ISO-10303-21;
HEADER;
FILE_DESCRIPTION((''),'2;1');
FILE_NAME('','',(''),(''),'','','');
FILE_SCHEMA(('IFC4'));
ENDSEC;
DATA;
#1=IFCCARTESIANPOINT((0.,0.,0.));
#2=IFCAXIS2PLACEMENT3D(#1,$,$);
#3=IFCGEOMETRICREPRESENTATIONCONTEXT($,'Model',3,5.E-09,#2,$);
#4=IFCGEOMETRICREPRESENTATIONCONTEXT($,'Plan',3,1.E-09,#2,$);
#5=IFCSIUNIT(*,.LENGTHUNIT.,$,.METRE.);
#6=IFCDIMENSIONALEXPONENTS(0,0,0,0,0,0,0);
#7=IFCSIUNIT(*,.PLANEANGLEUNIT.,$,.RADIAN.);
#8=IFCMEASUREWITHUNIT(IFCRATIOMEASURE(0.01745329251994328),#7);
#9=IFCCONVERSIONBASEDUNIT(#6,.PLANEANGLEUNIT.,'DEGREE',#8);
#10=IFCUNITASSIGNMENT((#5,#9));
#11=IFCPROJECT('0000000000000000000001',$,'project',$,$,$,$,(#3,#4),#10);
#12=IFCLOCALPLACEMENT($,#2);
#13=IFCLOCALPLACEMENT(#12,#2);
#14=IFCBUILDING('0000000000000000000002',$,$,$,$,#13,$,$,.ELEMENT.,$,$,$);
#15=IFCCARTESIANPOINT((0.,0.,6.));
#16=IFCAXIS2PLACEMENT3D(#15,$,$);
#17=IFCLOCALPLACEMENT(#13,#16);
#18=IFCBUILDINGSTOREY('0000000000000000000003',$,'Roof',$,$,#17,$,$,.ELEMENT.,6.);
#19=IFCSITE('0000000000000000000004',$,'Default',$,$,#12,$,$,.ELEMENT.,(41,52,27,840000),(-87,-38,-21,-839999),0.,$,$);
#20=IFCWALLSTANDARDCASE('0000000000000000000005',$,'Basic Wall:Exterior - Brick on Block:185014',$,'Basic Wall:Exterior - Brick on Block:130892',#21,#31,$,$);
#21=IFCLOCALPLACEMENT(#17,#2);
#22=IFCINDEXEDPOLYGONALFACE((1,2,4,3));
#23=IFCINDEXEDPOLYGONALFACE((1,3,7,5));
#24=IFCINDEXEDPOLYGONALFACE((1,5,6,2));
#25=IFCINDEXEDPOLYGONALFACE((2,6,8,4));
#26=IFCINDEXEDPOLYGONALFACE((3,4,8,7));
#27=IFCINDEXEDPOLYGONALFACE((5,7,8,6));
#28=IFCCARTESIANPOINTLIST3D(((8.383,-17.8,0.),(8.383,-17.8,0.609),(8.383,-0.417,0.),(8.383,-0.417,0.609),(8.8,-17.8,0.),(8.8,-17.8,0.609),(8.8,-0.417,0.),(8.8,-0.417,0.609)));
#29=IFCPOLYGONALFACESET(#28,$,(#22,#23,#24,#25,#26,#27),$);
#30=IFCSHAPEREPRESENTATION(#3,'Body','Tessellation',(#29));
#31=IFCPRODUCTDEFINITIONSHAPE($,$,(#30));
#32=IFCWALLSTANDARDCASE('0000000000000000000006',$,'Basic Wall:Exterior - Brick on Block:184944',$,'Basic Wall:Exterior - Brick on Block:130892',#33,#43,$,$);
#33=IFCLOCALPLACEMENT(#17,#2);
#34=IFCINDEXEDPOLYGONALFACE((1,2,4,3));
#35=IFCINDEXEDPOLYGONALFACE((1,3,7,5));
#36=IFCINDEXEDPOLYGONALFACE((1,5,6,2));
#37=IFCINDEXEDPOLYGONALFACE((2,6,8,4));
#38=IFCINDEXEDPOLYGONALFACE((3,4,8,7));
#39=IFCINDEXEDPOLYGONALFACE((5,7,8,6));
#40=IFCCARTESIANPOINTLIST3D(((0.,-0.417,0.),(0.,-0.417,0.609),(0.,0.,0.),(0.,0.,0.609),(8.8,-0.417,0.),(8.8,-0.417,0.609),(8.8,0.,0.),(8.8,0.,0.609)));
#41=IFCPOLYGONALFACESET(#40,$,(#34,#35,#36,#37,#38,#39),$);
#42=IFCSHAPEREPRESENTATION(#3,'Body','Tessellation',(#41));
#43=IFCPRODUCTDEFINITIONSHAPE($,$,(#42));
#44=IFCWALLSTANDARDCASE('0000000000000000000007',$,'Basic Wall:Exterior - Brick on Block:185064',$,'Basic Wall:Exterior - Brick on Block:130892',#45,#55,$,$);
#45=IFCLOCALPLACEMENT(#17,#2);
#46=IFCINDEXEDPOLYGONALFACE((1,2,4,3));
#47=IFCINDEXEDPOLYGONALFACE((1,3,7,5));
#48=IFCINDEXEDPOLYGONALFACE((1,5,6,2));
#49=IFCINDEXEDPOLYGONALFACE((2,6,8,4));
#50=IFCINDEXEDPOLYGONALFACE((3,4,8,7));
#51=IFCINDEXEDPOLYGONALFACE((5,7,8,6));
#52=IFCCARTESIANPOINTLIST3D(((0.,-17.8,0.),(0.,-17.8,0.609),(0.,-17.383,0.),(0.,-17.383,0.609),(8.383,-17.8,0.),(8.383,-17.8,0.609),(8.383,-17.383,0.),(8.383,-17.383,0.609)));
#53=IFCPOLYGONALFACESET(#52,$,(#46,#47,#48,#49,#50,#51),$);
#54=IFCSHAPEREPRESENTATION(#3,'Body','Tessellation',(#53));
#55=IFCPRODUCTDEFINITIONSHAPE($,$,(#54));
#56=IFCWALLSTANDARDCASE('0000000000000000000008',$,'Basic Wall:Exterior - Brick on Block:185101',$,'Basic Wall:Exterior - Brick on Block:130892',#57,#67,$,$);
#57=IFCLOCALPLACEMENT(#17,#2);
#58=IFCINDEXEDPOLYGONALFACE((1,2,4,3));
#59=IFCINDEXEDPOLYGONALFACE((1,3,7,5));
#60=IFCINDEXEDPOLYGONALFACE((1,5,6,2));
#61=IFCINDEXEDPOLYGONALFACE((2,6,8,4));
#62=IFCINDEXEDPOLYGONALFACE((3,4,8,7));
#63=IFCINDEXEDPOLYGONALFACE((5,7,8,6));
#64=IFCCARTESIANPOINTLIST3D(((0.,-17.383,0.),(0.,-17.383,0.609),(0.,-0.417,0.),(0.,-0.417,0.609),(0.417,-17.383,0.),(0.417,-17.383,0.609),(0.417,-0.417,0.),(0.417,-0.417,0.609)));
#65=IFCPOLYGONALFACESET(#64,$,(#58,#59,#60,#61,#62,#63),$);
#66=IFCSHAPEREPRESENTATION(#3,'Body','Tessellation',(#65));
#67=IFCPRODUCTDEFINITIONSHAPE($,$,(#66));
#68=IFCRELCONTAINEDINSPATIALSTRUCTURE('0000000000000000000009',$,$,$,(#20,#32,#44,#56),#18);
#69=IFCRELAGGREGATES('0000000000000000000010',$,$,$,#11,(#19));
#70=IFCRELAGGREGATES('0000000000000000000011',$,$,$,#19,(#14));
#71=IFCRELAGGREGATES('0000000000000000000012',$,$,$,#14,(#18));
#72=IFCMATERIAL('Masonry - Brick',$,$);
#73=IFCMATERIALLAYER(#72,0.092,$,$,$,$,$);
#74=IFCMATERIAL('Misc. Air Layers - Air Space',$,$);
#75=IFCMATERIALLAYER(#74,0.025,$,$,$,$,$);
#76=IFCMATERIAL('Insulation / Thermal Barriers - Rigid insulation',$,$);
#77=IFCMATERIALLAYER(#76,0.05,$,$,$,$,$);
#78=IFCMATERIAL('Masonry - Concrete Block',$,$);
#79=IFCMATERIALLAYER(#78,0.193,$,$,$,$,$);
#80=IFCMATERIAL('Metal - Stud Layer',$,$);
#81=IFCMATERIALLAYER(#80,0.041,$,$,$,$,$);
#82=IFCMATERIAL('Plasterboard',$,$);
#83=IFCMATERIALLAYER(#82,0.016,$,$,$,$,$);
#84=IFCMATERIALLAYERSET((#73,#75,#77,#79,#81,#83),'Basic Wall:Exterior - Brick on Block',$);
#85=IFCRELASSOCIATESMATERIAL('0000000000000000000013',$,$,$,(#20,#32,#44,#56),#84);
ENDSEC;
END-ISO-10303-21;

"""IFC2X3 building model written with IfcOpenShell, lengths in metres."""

from ifc_helpers import new_model, entity, si_unit, converted_unit, frame, frame_2d, origin, place, context, project, spatial, rectangle, extrude, material, layer, layer_set, layer_usage, element, save


model = new_model("IFC2X3")

# Units and contexts
model_context = context("Model", 3, precision=5e-09, world=origin())
plan_context = context("Plan", 3, precision=1e-09, world=origin())
ifc_project = project(units=[si_unit("LENGTHUNIT", "METRE"), converted_unit("PLANEANGLEUNIT", "DEGREE", entity("IfcRatioMeasure", 0.01745329251994328), si_unit("PLANEANGLEUNIT", "RADIAN"), dimensions=[0, 0, 0, 0, 0, 0, 0])], contexts=[model_context, plan_context])

# Site, building, storey
site_placement = place(None, origin())
site = spatial("IfcSite", under=ifc_project, at=site_placement, Name="Default", CompositionType="ELEMENT", RefLatitude=(41, 52, 27, 840000), RefLongitude=(-87, -38, -21, -839999), RefElevation=0.0)
building_placement = place(site_placement, origin())
building = spatial("IfcBuilding", under=site, at=building_placement, CompositionType="ELEMENT")
storey_placement = place(building_placement, frame((0.0, 0.0, 6.0)))
storey = spatial("IfcBuildingStorey", under=building, at=storey_placement, Name="Roof", CompositionType="ELEMENT", Elevation=6.0)

# Walls
ifc_material_1 = material(Name="Masonry - Brick")
ifc_layer_1 = layer(ifc_material_1, 0.092)
ifc_material_2 = material(Name="Misc. Air Layers - Air Space")
ifc_layer_2 = layer(ifc_material_2, 0.025)
ifc_material_3 = material(Name="Insulation / Thermal Barriers - Rigid insulation")
ifc_layer_3 = layer(ifc_material_3, 0.05)
ifc_material_4 = material(Name="Masonry - Concrete Block")
ifc_layer_4 = layer(ifc_material_4, 0.193)
ifc_material_5 = material(Name="Metal - Stud Layer")
ifc_layer_5 = layer(ifc_material_5, 0.041)
ifc_material_6 = material(Name="Plasterboard")
ifc_layer_6 = layer(ifc_material_6, 0.016)
ifc_layer_set = layer_set([ifc_layer_1, ifc_layer_2, ifc_layer_3, ifc_layer_4, ifc_layer_5, ifc_layer_6], Name="Basic Wall:Exterior - Brick on Block")
ifc_layer_usage = layer_usage(ifc_layer_set, "AXIS2", "NEGATIVE", 0.2085)
wall_1_placement = place(storey_placement, frame((8.5915, -0.417, 0.0), z_axis=(0.0, 0.0, 1.0), x_axis=(0.0, -1.0, 0.0)))
element("IfcWallStandardCase", 1, at=wall_1_placement, inside=storey, material=ifc_layer_usage, Name="Basic Wall:Exterior - Brick on Block:185014", ObjectType="Basic Wall:Exterior - Brick on Block:130892", context=model_context, shape_type="SweptSolid", body=[
    extrude(rectangle(XDim=17.383, YDim=0.417, at=frame_2d((8.6915, 0.0), x_axis=(-1.0, 0.0))), origin(), (0.0, 0.0, 1.0), 0.609),
])
wall_2_placement = place(storey_placement, frame((0.0, -0.2085, 0.0)))
element("IfcWallStandardCase", 2, at=wall_2_placement, inside=storey, material=ifc_layer_usage, Name="Basic Wall:Exterior - Brick on Block:184944", ObjectType="Basic Wall:Exterior - Brick on Block:130892", context=model_context, shape_type="SweptSolid", body=[
    extrude(rectangle(XDim=8.8, YDim=0.417, at=frame_2d((4.4, 0.0), x_axis=(-1.0, 0.0))), origin(), (0.0, 0.0, 1.0), 0.609),
])
wall_3_placement = place(storey_placement, frame((8.383, -17.5915, 0.0), z_axis=(0.0, 0.0, 1.0), x_axis=(-1.0, 0.0, 0.0)))
element("IfcWallStandardCase", 3, at=wall_3_placement, inside=storey, material=ifc_layer_usage, Name="Basic Wall:Exterior - Brick on Block:185064", ObjectType="Basic Wall:Exterior - Brick on Block:130892", context=model_context, shape_type="SweptSolid", body=[
    extrude(rectangle(XDim=8.383, YDim=0.417, at=frame_2d((4.1915, 0.0), x_axis=(-1.0, 0.0))), origin(), (0.0, 0.0, 1.0), 0.609),
])
wall_4_placement = place(storey_placement, frame((0.2085, -17.383, 0.0), z_axis=(0.0, 0.0, 1.0), x_axis=(0.0, 1.0, 0.0)))
element("IfcWallStandardCase", 4, at=wall_4_placement, inside=storey, material=ifc_layer_usage, Name="Basic Wall:Exterior - Brick on Block:185101", ObjectType="Basic Wall:Exterior - Brick on Block:130892", context=model_context, shape_type="SweptSolid", body=[
    extrude(rectangle(XDim=16.966, YDim=0.417, at=frame_2d((8.483, 0.0), x_axis=(-1.0, 0.0))), origin(), (0.0, 0.0, 1.0), 0.609),
])

save(model, "model.ifc")
